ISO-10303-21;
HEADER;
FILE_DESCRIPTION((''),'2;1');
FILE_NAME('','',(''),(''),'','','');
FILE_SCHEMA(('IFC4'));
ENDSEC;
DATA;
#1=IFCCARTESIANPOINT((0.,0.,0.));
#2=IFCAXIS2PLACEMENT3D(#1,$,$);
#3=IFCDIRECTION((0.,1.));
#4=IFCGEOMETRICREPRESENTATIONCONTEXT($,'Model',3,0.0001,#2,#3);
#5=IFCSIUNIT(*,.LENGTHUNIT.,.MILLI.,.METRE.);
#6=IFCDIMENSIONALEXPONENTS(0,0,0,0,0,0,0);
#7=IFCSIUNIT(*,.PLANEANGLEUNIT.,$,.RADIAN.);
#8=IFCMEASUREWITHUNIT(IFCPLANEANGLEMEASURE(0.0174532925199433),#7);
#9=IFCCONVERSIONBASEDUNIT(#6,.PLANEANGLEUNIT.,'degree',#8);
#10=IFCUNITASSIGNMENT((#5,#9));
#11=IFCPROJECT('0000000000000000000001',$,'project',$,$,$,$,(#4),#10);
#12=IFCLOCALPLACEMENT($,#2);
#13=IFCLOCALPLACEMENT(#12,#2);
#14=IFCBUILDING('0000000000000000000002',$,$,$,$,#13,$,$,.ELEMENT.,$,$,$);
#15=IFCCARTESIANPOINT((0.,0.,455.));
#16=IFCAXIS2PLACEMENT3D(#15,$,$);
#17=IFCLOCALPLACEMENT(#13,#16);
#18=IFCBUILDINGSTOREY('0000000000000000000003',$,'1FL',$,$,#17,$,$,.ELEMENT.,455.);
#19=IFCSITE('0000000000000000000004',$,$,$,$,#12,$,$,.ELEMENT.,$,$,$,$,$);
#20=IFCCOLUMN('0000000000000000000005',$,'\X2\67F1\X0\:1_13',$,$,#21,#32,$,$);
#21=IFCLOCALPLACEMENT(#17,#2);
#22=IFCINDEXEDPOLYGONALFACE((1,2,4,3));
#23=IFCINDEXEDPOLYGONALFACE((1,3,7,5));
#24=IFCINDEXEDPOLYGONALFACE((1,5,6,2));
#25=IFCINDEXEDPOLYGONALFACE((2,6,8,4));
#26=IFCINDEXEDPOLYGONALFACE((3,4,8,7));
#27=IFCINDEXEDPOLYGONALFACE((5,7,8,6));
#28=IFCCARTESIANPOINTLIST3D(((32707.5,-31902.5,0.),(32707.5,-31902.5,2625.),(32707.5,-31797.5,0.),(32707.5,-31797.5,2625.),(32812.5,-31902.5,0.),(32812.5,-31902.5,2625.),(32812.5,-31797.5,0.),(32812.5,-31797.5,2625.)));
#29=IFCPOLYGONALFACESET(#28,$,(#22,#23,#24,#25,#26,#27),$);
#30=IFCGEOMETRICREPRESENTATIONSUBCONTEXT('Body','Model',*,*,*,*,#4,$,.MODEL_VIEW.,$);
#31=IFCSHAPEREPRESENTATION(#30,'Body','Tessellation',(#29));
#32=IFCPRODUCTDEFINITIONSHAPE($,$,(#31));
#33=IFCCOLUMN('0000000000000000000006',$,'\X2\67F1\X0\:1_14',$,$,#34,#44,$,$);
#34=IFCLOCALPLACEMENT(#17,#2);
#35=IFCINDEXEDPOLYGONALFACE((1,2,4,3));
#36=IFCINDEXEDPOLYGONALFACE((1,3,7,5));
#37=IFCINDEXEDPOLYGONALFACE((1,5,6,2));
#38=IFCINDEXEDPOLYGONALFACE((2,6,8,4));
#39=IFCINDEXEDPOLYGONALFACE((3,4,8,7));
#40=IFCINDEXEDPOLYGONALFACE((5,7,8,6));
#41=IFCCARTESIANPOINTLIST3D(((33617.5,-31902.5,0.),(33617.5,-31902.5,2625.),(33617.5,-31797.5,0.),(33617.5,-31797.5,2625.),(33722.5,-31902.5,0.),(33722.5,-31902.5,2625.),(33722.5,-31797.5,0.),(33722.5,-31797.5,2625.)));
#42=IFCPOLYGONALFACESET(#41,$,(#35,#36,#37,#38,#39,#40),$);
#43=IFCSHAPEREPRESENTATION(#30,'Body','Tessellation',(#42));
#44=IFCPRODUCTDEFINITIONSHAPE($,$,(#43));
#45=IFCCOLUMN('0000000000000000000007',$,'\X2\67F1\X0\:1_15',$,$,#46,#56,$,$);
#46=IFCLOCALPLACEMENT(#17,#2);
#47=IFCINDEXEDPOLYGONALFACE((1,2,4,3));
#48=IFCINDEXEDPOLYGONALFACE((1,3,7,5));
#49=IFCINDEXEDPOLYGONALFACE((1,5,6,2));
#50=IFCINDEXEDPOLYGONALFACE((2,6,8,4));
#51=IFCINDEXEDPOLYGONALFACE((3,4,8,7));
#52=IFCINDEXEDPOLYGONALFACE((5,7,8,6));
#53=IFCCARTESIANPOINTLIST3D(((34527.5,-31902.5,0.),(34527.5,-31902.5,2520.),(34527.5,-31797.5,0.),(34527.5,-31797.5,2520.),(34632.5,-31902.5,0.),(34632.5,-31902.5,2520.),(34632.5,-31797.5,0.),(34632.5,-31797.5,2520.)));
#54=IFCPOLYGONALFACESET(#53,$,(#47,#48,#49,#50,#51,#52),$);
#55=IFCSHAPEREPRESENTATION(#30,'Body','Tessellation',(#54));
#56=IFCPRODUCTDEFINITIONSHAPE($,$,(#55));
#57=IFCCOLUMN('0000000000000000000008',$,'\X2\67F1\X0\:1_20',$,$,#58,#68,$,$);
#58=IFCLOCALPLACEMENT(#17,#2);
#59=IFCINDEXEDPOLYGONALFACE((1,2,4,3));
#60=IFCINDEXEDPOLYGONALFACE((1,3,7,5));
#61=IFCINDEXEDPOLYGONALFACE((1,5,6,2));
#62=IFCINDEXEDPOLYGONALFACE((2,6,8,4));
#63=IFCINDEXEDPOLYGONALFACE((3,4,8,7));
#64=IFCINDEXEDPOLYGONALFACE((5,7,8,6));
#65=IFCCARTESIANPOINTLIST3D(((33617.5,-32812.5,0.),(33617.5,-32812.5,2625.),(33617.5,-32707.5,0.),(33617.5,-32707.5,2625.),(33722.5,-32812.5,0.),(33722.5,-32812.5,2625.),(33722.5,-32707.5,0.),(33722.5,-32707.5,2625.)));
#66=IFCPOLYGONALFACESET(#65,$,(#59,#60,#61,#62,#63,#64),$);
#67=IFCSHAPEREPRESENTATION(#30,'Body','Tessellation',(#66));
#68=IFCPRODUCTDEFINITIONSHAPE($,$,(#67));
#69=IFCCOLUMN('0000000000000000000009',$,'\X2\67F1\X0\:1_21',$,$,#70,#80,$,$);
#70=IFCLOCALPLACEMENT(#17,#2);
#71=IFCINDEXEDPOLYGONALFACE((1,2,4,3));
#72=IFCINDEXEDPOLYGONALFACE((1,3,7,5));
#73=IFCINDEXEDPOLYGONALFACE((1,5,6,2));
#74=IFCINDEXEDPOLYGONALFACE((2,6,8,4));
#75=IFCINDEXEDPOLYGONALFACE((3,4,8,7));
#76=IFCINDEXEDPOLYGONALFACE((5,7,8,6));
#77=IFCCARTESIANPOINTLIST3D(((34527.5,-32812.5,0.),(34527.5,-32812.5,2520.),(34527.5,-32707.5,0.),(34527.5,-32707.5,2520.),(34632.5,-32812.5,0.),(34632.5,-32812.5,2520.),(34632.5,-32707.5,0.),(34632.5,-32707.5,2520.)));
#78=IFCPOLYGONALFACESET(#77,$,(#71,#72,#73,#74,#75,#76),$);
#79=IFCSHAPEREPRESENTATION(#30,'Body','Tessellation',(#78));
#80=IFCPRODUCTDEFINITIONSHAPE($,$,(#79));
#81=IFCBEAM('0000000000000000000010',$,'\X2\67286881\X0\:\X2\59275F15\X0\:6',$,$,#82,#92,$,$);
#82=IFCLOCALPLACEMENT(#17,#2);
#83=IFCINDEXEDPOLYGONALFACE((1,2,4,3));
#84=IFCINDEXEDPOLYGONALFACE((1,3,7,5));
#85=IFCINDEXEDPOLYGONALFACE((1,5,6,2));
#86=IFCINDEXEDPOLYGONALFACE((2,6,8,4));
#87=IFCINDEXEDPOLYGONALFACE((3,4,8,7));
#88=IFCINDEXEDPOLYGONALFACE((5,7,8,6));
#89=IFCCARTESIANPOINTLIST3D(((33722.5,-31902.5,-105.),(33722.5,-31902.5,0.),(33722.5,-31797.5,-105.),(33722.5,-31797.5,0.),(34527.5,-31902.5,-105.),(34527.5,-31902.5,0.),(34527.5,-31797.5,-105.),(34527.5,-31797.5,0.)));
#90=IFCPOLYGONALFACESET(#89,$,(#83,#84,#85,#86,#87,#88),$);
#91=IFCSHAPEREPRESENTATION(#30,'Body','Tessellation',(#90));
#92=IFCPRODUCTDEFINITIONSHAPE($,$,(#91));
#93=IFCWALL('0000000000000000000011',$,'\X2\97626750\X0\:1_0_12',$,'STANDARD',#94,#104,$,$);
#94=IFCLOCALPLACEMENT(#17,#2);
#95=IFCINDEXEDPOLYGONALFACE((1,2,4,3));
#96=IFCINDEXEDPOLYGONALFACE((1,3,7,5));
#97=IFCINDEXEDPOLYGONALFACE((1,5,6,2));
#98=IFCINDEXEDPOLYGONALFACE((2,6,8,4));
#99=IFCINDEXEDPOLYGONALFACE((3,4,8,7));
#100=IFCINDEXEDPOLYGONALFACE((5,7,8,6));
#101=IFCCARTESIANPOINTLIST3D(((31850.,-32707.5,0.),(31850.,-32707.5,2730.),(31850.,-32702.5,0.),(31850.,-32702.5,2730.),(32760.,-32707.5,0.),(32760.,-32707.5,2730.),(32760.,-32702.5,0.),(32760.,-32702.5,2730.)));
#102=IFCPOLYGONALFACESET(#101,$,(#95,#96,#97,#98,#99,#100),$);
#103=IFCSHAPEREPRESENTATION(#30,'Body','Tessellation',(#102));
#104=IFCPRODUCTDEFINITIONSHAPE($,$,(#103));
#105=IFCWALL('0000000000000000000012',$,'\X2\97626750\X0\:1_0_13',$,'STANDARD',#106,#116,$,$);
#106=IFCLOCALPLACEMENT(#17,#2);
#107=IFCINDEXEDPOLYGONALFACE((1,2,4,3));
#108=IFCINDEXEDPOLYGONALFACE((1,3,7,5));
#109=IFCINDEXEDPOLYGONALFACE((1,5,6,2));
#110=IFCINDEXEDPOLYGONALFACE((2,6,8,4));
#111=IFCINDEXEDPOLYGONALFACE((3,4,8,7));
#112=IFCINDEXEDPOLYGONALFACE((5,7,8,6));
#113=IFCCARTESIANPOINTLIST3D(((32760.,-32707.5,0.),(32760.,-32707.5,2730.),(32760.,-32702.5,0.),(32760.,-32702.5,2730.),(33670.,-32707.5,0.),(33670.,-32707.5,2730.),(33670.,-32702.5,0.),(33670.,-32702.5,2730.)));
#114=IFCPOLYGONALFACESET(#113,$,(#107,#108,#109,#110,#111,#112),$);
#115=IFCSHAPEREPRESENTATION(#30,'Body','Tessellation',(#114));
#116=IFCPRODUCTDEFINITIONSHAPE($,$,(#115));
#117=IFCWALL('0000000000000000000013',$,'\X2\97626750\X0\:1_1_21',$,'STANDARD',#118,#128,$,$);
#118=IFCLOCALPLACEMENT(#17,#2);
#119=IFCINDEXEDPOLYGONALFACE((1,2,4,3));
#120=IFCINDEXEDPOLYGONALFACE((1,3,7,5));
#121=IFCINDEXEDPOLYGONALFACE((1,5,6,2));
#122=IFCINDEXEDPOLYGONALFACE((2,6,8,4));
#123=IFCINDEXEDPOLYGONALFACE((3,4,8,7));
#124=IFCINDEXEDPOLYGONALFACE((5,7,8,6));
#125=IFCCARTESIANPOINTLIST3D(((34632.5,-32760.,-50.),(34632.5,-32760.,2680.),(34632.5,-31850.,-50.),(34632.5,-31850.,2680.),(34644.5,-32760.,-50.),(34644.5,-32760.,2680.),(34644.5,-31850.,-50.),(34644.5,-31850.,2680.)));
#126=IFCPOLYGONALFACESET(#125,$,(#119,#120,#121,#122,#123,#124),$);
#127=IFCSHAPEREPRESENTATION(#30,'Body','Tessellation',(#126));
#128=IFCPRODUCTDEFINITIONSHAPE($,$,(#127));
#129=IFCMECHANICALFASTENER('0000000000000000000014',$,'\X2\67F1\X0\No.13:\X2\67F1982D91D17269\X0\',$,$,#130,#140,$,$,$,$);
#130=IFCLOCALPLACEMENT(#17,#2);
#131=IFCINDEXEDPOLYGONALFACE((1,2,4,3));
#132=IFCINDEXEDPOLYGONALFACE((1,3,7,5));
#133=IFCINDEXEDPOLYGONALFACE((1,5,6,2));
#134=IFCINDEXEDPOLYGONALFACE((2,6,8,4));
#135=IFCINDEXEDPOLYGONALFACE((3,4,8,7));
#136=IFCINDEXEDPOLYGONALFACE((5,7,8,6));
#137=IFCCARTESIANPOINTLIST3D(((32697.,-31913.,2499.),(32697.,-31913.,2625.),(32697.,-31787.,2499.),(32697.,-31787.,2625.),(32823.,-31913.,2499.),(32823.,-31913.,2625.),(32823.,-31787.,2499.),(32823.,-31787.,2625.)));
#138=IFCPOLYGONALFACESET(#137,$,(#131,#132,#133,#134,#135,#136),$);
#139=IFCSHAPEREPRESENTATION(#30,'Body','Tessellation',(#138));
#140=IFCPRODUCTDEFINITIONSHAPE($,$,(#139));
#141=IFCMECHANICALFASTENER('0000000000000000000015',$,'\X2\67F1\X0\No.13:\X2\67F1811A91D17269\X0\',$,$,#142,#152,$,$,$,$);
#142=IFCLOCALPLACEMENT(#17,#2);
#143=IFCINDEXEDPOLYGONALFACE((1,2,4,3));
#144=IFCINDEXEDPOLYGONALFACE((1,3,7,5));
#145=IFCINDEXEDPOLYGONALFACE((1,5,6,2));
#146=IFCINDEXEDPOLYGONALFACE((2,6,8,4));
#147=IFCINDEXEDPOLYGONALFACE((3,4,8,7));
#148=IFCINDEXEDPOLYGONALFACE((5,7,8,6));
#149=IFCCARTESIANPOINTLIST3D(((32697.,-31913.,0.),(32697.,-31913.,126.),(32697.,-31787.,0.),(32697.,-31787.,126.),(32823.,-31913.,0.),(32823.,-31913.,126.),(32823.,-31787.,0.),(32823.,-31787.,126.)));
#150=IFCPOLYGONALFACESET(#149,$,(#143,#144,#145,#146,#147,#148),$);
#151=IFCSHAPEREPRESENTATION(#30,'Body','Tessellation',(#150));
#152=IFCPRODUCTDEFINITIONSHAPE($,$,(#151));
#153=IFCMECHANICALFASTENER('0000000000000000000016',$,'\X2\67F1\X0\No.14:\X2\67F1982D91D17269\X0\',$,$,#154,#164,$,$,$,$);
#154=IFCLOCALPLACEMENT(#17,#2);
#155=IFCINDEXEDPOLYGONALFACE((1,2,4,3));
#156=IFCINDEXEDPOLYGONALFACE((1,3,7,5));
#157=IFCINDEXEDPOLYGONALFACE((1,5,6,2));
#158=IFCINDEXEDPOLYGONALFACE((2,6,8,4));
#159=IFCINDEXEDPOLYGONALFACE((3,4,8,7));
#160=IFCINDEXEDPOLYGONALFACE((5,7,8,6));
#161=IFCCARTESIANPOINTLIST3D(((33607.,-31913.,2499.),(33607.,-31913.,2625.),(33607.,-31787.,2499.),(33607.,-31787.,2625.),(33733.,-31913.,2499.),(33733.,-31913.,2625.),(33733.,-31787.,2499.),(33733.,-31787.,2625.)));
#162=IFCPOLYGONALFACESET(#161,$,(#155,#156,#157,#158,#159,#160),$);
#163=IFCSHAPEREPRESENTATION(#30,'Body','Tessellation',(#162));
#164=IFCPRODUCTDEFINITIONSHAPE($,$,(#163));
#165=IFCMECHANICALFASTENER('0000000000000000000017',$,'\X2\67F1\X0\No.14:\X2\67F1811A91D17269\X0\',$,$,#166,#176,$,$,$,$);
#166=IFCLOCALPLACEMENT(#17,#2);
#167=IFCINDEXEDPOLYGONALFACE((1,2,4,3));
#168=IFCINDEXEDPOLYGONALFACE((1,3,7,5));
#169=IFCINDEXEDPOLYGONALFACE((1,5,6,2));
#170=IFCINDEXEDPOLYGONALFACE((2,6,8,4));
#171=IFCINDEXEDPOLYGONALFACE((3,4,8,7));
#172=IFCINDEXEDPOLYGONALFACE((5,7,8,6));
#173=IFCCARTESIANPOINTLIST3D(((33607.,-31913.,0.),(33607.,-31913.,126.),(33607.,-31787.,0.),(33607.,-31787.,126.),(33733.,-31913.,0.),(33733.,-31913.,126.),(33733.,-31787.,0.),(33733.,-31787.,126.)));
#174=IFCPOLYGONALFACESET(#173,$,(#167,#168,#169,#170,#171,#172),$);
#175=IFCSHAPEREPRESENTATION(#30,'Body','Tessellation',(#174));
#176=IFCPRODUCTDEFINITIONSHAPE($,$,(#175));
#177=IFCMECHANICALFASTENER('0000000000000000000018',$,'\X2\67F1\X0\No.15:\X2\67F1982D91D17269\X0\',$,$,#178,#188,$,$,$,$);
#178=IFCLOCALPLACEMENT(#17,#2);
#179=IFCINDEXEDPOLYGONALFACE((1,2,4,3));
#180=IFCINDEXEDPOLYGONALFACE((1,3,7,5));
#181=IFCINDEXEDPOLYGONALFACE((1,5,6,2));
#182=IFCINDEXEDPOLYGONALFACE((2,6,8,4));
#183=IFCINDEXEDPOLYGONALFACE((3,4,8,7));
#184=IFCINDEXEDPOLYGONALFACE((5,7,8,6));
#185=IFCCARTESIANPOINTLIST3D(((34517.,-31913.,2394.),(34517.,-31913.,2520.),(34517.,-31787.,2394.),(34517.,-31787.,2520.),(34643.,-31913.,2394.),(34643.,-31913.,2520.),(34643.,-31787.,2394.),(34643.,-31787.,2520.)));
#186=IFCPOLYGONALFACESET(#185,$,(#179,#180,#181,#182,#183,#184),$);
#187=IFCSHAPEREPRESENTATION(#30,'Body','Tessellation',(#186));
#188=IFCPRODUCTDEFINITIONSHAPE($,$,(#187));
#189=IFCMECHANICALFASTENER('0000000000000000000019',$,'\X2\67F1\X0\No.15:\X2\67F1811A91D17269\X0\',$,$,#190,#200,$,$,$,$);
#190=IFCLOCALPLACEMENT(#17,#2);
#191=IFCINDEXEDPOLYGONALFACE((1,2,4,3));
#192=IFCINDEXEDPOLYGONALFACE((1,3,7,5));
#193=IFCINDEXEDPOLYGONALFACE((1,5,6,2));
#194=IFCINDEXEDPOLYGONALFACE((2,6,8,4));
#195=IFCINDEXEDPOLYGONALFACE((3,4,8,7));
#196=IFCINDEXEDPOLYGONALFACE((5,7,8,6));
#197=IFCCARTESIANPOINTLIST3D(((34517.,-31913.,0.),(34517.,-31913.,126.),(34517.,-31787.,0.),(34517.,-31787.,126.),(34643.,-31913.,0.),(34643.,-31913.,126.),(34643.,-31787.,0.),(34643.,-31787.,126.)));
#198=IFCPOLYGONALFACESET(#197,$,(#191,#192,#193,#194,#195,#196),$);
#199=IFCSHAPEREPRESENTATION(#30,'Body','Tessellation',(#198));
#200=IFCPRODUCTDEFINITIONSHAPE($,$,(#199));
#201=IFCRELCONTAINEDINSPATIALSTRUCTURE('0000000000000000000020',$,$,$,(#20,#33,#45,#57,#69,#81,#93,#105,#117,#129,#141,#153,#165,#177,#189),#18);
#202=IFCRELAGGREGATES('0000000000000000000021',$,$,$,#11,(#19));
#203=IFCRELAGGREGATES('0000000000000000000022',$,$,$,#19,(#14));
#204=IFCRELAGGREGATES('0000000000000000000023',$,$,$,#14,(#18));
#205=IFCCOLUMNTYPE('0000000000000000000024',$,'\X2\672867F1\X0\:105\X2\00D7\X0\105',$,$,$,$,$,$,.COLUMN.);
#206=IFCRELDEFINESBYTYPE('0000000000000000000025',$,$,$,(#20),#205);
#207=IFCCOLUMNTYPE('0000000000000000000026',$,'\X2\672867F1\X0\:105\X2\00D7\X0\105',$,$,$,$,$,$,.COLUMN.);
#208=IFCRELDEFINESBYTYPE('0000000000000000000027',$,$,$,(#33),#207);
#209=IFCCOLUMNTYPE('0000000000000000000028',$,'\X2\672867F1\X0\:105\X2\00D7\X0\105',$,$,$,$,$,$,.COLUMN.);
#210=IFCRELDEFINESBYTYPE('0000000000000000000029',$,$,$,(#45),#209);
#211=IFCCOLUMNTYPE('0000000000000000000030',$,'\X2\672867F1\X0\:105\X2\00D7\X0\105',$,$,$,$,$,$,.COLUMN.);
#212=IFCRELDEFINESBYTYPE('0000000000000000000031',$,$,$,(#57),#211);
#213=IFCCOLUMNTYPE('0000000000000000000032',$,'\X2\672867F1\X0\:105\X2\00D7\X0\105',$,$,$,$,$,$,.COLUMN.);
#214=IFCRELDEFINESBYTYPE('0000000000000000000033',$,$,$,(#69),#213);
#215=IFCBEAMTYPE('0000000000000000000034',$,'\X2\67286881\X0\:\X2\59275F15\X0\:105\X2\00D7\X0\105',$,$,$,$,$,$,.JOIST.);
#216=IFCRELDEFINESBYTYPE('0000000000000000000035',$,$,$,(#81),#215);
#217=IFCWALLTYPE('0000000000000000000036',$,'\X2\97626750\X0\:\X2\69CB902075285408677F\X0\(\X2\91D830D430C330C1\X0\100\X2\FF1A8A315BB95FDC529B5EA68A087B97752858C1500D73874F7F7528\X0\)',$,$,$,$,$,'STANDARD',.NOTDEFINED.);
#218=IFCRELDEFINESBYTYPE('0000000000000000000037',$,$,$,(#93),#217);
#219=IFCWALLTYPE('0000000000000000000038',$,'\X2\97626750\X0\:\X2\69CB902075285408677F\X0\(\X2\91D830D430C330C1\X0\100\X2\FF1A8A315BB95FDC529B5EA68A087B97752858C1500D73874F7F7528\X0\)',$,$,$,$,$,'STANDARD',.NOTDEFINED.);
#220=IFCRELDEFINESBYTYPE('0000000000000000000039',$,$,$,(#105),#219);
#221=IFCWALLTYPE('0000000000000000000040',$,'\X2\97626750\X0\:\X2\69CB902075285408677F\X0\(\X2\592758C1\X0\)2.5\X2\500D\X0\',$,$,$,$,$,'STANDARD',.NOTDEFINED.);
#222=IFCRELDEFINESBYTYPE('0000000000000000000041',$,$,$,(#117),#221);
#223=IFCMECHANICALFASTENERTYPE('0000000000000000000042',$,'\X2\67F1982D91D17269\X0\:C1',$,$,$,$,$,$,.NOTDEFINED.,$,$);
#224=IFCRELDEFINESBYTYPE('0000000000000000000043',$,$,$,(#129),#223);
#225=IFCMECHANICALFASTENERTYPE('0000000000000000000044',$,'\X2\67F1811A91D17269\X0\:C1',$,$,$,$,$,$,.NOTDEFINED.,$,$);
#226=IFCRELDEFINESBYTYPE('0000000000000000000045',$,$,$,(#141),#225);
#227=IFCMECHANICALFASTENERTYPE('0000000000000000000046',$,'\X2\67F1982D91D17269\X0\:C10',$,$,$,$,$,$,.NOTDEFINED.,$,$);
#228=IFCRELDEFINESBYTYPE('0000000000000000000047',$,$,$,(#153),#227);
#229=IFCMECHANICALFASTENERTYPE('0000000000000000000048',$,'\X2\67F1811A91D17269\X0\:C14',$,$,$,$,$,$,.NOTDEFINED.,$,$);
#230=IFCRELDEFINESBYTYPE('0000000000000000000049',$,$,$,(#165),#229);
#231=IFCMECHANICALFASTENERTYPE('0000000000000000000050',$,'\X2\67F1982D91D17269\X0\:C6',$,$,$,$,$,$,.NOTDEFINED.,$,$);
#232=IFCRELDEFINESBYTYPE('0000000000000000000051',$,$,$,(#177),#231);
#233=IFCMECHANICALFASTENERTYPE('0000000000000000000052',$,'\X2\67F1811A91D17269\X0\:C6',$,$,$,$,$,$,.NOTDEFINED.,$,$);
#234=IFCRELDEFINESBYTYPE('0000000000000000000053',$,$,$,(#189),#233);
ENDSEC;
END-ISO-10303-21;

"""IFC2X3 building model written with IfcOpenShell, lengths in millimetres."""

from ifc_helpers import new_model, entity, si_unit, converted_unit, direction, frame, origin, origin_with_axes, origin_2d, place, context, subcontext, project, spatial, polyline, rectangle, outline, extrude, type_object, element, save


model = new_model("IFC2X3")

# Units and contexts
model_context = context("Model", 3, precision=0.0001, world=origin(), true_north=direction((0.0, 1.0)))
body_context = subcontext(model_context, "Body", "Model", "MODEL_VIEW")
ifc_project = project(units=[si_unit("LENGTHUNIT", "METRE", prefix="MILLI"), converted_unit("PLANEANGLEUNIT", "degree", entity("IfcPlaneAngleMeasure", 0.0174532925199433), si_unit("PLANEANGLEUNIT", "RADIAN"), dimensions=[0, 0, 0, 0, 0, 0, 0])], contexts=[model_context])

# Site, building, storey
site_placement = place(None, origin())
site = spatial("IfcSite", under=ifc_project, at=site_placement, CompositionType="ELEMENT")
building_placement = place(site_placement, origin())
building = spatial("IfcBuilding", under=site, at=building_placement, CompositionType="ELEMENT")
storey_placement = place(building_placement, frame((0.0, 0.0, 455.0)))
storey = spatial("IfcBuildingStorey", under=building, at=storey_placement, Name="1FL", CompositionType="ELEMENT", Elevation=455.0)

# Columns
column_type_1 = type_object("IfcColumnType", Name="木柱:105×105", PredefinedType="COLUMN")
column_1_placement = place(storey_placement, frame((32760.0, -31850.0, 0.0)))
element("IfcColumn", 1, at=column_1_placement, inside=storey, type_object=column_type_1, Name="柱:1_13", context=body_context, shape_type="SweptSolid", body=[
    extrude(rectangle(XDim=105.0, YDim=105.0, at=origin_2d()), origin_with_axes(), (0.0, 0.0, 1.0), 2625.0),
])
column_type_2 = type_object("IfcColumnType", Name="木柱:105×105", PredefinedType="COLUMN")
column_2_placement = place(storey_placement, frame((33670.0, -31850.0, 0.0)))
element("IfcColumn", 2, at=column_2_placement, inside=storey, type_object=column_type_2, Name="柱:1_14", context=body_context, shape_type="SweptSolid", body=[
    extrude(rectangle(XDim=105.0, YDim=105.0, at=origin_2d()), origin_with_axes(), (0.0, 0.0, 1.0), 2625.0),
])
column_type_3 = type_object("IfcColumnType", Name="木柱:105×105", PredefinedType="COLUMN")
column_3_placement = place(storey_placement, frame((34580.0, -31850.0, 0.0)))
element("IfcColumn", 3, at=column_3_placement, inside=storey, type_object=column_type_3, Name="柱:1_15", context=body_context, shape_type="SweptSolid", body=[
    extrude(rectangle(XDim=105.0, YDim=105.0, at=origin_2d()), origin_with_axes(), (0.0, 0.0, 1.0), 2520.0),
])
column_type_4 = type_object("IfcColumnType", Name="木柱:105×105", PredefinedType="COLUMN")
column_4_placement = place(storey_placement, frame((33670.0, -32760.0, 0.0)))
element("IfcColumn", 4, at=column_4_placement, inside=storey, type_object=column_type_4, Name="柱:1_20", context=body_context, shape_type="SweptSolid", body=[
    extrude(rectangle(XDim=105.0, YDim=105.0, at=origin_2d()), origin_with_axes(), (0.0, 0.0, 1.0), 2625.0),
])
column_type_5 = type_object("IfcColumnType", Name="木柱:105×105", PredefinedType="COLUMN")
column_5_placement = place(storey_placement, frame((34580.0, -32760.0, 0.0)))
element("IfcColumn", 5, at=column_5_placement, inside=storey, type_object=column_type_5, Name="柱:1_21", context=body_context, shape_type="SweptSolid", body=[
    extrude(rectangle(XDim=105.0, YDim=105.0, at=origin_2d()), origin_with_axes(), (0.0, 0.0, 1.0), 2520.0),
])

# Beam
beam_type = type_object("IfcBeamType", Name="木梁:大引:105×105", PredefinedType="JOIST")
beam_placement = place(storey_placement, frame((33722.5, -31850.0, -52.5), z_axis=(1.0, 0.0, 0.0), x_axis=(0.0, 1.0, 0.0)))
element("IfcBeam", 6, at=beam_placement, inside=storey, type_object=beam_type, Name="木梁:大引:6", context=body_context, shape_type="SweptSolid", body=[
    extrude(rectangle(XDim=105.0, YDim=105.0, at=origin_2d()), origin_with_axes(), (0.0, 0.0, 1.0), 805.0),
])

# Walls
wall_type_1 = type_object("IfcWallType", Name="面材:構造用合板(釘ピッチ100：許容応力度計算用壁倍率使用)", ElementType="STANDARD", PredefinedType="NOTDEFINED")
wall_1_placement = place(storey_placement, frame((32305.0, -32702.5, 0.0), z_axis=(0.0, -1.0, 0.0), x_axis=(1.0, 0.0, 0.0)))
element("IfcWall", 7, at=wall_1_placement, inside=storey, type_object=wall_type_1, Name="面材:1_0_12", ObjectType="STANDARD", context=body_context, shape_type="SweptSolid", body=[
    extrude(outline(polyline([(455.0, 0.0, 0.0), (-455.0, 0.0, 0.0), (-455.0, 2730.0, 0.0), (455.0, 2730.0, 0.0), (455.0, 0.0, 0.0)])), origin_with_axes(), (0.0, 0.0, 1.0), 5.0),
])
wall_type_2 = type_object("IfcWallType", Name="面材:構造用合板(釘ピッチ100：許容応力度計算用壁倍率使用)", ElementType="STANDARD", PredefinedType="NOTDEFINED")
wall_2_placement = place(storey_placement, frame((33215.0, -32702.5, 0.0), z_axis=(0.0, -1.0, 0.0), x_axis=(1.0, 0.0, 0.0)))
element("IfcWall", 8, at=wall_2_placement, inside=storey, type_object=wall_type_2, Name="面材:1_0_13", ObjectType="STANDARD", context=body_context, shape_type="SweptSolid", body=[
    extrude(outline(polyline([(455.0, 0.0, 0.0), (-455.0, 0.0, 0.0), (-455.0, 2730.0, 0.0), (455.0, 2730.0, 0.0), (455.0, 0.0, 0.0)])), origin_with_axes(), (0.0, 0.0, 1.0), 5.0),
])
wall_type_3 = type_object("IfcWallType", Name="面材:構造用合板(大壁)2.5倍", ElementType="STANDARD", PredefinedType="NOTDEFINED")
wall_3_placement = place(storey_placement, frame((34644.5, -32305.0, -50.0), z_axis=(-1.0, 0.0, 0.0), x_axis=(0.0, -1.0, 0.0)))
element("IfcWall", 9, at=wall_3_placement, inside=storey, type_object=wall_type_3, Name="面材:1_1_21", ObjectType="STANDARD", context=body_context, shape_type="SweptSolid", body=[
    extrude(outline(polyline([(455.0, 0.0, 0.0), (-455.0, 0.0, 0.0), (-455.0, 2730.0, 0.0), (455.0, 2730.0, 0.0), (455.0, 0.0, 0.0)])), origin_with_axes(), (0.0, 0.0, 1.0), 12.0),
])

# Mechanical fasteners
mechanical_fastener_type_1 = type_object("IfcMechanicalFastenerType", Name="柱頭金物:C1")
mechanical_fastener_1_placement = place(storey_placement, frame((32760.0, -31850.0, 2499.0)))
element("IfcMechanicalFastener", 10, at=mechanical_fastener_1_placement, inside=storey, type_object=mechanical_fastener_type_1, Name="柱No.13:柱頭金物", context=body_context, shape_type="SweptSolid", body=[
    extrude(rectangle(XDim=126.0, YDim=126.0, at=origin_2d()), origin_with_axes(), (0.0, 0.0, 1.0), 126.0),
])
mechanical_fastener_type_2 = type_object("IfcMechanicalFastenerType", Name="柱脚金物:C1")
mechanical_fastener_2_placement = place(storey_placement, frame((32760.0, -31850.0, 0.0)))
element("IfcMechanicalFastener", 11, at=mechanical_fastener_2_placement, inside=storey, type_object=mechanical_fastener_type_2, Name="柱No.13:柱脚金物", context=body_context, shape_type="SweptSolid", body=[
    extrude(rectangle(XDim=126.0, YDim=126.0, at=origin_2d()), origin_with_axes(), (0.0, 0.0, 1.0), 126.0),
])
mechanical_fastener_type_3 = type_object("IfcMechanicalFastenerType", Name="柱頭金物:C10")
mechanical_fastener_3_placement = place(storey_placement, frame((33670.0, -31850.0, 2499.0)))
element("IfcMechanicalFastener", 12, at=mechanical_fastener_3_placement, inside=storey, type_object=mechanical_fastener_type_3, Name="柱No.14:柱頭金物", context=body_context, shape_type="SweptSolid", body=[
    extrude(rectangle(XDim=126.0, YDim=126.0, at=origin_2d()), origin_with_axes(), (0.0, 0.0, 1.0), 126.0),
])
mechanical_fastener_type_4 = type_object("IfcMechanicalFastenerType", Name="柱脚金物:C14")
mechanical_fastener_4_placement = place(storey_placement, frame((33670.0, -31850.0, 0.0)))
element("IfcMechanicalFastener", 13, at=mechanical_fastener_4_placement, inside=storey, type_object=mechanical_fastener_type_4, Name="柱No.14:柱脚金物", context=body_context, shape_type="SweptSolid", body=[
    extrude(rectangle(XDim=126.0, YDim=126.0, at=origin_2d()), origin_with_axes(), (0.0, 0.0, 1.0), 126.0),
])
mechanical_fastener_type_5 = type_object("IfcMechanicalFastenerType", Name="柱頭金物:C6")
mechanical_fastener_5_placement = place(storey_placement, frame((34580.0, -31850.0, 2394.0)))
element("IfcMechanicalFastener", 14, at=mechanical_fastener_5_placement, inside=storey, type_object=mechanical_fastener_type_5, Name="柱No.15:柱頭金物", context=body_context, shape_type="SweptSolid", body=[
    extrude(rectangle(XDim=126.0, YDim=126.0, at=origin_2d()), origin_with_axes(), (0.0, 0.0, 1.0), 126.0),
])
mechanical_fastener_type_6 = type_object("IfcMechanicalFastenerType", Name="柱脚金物:C6")
mechanical_fastener_6_placement = place(storey_placement, frame((34580.0, -31850.0, 0.0)))
element("IfcMechanicalFastener", 15, at=mechanical_fastener_6_placement, inside=storey, type_object=mechanical_fastener_type_6, Name="柱No.15:柱脚金物", context=body_context, shape_type="SweptSolid", body=[
    extrude(rectangle(XDim=126.0, YDim=126.0, at=origin_2d()), origin_with_axes(), (0.0, 0.0, 1.0), 126.0),
])

save(model, "model.ifc")
